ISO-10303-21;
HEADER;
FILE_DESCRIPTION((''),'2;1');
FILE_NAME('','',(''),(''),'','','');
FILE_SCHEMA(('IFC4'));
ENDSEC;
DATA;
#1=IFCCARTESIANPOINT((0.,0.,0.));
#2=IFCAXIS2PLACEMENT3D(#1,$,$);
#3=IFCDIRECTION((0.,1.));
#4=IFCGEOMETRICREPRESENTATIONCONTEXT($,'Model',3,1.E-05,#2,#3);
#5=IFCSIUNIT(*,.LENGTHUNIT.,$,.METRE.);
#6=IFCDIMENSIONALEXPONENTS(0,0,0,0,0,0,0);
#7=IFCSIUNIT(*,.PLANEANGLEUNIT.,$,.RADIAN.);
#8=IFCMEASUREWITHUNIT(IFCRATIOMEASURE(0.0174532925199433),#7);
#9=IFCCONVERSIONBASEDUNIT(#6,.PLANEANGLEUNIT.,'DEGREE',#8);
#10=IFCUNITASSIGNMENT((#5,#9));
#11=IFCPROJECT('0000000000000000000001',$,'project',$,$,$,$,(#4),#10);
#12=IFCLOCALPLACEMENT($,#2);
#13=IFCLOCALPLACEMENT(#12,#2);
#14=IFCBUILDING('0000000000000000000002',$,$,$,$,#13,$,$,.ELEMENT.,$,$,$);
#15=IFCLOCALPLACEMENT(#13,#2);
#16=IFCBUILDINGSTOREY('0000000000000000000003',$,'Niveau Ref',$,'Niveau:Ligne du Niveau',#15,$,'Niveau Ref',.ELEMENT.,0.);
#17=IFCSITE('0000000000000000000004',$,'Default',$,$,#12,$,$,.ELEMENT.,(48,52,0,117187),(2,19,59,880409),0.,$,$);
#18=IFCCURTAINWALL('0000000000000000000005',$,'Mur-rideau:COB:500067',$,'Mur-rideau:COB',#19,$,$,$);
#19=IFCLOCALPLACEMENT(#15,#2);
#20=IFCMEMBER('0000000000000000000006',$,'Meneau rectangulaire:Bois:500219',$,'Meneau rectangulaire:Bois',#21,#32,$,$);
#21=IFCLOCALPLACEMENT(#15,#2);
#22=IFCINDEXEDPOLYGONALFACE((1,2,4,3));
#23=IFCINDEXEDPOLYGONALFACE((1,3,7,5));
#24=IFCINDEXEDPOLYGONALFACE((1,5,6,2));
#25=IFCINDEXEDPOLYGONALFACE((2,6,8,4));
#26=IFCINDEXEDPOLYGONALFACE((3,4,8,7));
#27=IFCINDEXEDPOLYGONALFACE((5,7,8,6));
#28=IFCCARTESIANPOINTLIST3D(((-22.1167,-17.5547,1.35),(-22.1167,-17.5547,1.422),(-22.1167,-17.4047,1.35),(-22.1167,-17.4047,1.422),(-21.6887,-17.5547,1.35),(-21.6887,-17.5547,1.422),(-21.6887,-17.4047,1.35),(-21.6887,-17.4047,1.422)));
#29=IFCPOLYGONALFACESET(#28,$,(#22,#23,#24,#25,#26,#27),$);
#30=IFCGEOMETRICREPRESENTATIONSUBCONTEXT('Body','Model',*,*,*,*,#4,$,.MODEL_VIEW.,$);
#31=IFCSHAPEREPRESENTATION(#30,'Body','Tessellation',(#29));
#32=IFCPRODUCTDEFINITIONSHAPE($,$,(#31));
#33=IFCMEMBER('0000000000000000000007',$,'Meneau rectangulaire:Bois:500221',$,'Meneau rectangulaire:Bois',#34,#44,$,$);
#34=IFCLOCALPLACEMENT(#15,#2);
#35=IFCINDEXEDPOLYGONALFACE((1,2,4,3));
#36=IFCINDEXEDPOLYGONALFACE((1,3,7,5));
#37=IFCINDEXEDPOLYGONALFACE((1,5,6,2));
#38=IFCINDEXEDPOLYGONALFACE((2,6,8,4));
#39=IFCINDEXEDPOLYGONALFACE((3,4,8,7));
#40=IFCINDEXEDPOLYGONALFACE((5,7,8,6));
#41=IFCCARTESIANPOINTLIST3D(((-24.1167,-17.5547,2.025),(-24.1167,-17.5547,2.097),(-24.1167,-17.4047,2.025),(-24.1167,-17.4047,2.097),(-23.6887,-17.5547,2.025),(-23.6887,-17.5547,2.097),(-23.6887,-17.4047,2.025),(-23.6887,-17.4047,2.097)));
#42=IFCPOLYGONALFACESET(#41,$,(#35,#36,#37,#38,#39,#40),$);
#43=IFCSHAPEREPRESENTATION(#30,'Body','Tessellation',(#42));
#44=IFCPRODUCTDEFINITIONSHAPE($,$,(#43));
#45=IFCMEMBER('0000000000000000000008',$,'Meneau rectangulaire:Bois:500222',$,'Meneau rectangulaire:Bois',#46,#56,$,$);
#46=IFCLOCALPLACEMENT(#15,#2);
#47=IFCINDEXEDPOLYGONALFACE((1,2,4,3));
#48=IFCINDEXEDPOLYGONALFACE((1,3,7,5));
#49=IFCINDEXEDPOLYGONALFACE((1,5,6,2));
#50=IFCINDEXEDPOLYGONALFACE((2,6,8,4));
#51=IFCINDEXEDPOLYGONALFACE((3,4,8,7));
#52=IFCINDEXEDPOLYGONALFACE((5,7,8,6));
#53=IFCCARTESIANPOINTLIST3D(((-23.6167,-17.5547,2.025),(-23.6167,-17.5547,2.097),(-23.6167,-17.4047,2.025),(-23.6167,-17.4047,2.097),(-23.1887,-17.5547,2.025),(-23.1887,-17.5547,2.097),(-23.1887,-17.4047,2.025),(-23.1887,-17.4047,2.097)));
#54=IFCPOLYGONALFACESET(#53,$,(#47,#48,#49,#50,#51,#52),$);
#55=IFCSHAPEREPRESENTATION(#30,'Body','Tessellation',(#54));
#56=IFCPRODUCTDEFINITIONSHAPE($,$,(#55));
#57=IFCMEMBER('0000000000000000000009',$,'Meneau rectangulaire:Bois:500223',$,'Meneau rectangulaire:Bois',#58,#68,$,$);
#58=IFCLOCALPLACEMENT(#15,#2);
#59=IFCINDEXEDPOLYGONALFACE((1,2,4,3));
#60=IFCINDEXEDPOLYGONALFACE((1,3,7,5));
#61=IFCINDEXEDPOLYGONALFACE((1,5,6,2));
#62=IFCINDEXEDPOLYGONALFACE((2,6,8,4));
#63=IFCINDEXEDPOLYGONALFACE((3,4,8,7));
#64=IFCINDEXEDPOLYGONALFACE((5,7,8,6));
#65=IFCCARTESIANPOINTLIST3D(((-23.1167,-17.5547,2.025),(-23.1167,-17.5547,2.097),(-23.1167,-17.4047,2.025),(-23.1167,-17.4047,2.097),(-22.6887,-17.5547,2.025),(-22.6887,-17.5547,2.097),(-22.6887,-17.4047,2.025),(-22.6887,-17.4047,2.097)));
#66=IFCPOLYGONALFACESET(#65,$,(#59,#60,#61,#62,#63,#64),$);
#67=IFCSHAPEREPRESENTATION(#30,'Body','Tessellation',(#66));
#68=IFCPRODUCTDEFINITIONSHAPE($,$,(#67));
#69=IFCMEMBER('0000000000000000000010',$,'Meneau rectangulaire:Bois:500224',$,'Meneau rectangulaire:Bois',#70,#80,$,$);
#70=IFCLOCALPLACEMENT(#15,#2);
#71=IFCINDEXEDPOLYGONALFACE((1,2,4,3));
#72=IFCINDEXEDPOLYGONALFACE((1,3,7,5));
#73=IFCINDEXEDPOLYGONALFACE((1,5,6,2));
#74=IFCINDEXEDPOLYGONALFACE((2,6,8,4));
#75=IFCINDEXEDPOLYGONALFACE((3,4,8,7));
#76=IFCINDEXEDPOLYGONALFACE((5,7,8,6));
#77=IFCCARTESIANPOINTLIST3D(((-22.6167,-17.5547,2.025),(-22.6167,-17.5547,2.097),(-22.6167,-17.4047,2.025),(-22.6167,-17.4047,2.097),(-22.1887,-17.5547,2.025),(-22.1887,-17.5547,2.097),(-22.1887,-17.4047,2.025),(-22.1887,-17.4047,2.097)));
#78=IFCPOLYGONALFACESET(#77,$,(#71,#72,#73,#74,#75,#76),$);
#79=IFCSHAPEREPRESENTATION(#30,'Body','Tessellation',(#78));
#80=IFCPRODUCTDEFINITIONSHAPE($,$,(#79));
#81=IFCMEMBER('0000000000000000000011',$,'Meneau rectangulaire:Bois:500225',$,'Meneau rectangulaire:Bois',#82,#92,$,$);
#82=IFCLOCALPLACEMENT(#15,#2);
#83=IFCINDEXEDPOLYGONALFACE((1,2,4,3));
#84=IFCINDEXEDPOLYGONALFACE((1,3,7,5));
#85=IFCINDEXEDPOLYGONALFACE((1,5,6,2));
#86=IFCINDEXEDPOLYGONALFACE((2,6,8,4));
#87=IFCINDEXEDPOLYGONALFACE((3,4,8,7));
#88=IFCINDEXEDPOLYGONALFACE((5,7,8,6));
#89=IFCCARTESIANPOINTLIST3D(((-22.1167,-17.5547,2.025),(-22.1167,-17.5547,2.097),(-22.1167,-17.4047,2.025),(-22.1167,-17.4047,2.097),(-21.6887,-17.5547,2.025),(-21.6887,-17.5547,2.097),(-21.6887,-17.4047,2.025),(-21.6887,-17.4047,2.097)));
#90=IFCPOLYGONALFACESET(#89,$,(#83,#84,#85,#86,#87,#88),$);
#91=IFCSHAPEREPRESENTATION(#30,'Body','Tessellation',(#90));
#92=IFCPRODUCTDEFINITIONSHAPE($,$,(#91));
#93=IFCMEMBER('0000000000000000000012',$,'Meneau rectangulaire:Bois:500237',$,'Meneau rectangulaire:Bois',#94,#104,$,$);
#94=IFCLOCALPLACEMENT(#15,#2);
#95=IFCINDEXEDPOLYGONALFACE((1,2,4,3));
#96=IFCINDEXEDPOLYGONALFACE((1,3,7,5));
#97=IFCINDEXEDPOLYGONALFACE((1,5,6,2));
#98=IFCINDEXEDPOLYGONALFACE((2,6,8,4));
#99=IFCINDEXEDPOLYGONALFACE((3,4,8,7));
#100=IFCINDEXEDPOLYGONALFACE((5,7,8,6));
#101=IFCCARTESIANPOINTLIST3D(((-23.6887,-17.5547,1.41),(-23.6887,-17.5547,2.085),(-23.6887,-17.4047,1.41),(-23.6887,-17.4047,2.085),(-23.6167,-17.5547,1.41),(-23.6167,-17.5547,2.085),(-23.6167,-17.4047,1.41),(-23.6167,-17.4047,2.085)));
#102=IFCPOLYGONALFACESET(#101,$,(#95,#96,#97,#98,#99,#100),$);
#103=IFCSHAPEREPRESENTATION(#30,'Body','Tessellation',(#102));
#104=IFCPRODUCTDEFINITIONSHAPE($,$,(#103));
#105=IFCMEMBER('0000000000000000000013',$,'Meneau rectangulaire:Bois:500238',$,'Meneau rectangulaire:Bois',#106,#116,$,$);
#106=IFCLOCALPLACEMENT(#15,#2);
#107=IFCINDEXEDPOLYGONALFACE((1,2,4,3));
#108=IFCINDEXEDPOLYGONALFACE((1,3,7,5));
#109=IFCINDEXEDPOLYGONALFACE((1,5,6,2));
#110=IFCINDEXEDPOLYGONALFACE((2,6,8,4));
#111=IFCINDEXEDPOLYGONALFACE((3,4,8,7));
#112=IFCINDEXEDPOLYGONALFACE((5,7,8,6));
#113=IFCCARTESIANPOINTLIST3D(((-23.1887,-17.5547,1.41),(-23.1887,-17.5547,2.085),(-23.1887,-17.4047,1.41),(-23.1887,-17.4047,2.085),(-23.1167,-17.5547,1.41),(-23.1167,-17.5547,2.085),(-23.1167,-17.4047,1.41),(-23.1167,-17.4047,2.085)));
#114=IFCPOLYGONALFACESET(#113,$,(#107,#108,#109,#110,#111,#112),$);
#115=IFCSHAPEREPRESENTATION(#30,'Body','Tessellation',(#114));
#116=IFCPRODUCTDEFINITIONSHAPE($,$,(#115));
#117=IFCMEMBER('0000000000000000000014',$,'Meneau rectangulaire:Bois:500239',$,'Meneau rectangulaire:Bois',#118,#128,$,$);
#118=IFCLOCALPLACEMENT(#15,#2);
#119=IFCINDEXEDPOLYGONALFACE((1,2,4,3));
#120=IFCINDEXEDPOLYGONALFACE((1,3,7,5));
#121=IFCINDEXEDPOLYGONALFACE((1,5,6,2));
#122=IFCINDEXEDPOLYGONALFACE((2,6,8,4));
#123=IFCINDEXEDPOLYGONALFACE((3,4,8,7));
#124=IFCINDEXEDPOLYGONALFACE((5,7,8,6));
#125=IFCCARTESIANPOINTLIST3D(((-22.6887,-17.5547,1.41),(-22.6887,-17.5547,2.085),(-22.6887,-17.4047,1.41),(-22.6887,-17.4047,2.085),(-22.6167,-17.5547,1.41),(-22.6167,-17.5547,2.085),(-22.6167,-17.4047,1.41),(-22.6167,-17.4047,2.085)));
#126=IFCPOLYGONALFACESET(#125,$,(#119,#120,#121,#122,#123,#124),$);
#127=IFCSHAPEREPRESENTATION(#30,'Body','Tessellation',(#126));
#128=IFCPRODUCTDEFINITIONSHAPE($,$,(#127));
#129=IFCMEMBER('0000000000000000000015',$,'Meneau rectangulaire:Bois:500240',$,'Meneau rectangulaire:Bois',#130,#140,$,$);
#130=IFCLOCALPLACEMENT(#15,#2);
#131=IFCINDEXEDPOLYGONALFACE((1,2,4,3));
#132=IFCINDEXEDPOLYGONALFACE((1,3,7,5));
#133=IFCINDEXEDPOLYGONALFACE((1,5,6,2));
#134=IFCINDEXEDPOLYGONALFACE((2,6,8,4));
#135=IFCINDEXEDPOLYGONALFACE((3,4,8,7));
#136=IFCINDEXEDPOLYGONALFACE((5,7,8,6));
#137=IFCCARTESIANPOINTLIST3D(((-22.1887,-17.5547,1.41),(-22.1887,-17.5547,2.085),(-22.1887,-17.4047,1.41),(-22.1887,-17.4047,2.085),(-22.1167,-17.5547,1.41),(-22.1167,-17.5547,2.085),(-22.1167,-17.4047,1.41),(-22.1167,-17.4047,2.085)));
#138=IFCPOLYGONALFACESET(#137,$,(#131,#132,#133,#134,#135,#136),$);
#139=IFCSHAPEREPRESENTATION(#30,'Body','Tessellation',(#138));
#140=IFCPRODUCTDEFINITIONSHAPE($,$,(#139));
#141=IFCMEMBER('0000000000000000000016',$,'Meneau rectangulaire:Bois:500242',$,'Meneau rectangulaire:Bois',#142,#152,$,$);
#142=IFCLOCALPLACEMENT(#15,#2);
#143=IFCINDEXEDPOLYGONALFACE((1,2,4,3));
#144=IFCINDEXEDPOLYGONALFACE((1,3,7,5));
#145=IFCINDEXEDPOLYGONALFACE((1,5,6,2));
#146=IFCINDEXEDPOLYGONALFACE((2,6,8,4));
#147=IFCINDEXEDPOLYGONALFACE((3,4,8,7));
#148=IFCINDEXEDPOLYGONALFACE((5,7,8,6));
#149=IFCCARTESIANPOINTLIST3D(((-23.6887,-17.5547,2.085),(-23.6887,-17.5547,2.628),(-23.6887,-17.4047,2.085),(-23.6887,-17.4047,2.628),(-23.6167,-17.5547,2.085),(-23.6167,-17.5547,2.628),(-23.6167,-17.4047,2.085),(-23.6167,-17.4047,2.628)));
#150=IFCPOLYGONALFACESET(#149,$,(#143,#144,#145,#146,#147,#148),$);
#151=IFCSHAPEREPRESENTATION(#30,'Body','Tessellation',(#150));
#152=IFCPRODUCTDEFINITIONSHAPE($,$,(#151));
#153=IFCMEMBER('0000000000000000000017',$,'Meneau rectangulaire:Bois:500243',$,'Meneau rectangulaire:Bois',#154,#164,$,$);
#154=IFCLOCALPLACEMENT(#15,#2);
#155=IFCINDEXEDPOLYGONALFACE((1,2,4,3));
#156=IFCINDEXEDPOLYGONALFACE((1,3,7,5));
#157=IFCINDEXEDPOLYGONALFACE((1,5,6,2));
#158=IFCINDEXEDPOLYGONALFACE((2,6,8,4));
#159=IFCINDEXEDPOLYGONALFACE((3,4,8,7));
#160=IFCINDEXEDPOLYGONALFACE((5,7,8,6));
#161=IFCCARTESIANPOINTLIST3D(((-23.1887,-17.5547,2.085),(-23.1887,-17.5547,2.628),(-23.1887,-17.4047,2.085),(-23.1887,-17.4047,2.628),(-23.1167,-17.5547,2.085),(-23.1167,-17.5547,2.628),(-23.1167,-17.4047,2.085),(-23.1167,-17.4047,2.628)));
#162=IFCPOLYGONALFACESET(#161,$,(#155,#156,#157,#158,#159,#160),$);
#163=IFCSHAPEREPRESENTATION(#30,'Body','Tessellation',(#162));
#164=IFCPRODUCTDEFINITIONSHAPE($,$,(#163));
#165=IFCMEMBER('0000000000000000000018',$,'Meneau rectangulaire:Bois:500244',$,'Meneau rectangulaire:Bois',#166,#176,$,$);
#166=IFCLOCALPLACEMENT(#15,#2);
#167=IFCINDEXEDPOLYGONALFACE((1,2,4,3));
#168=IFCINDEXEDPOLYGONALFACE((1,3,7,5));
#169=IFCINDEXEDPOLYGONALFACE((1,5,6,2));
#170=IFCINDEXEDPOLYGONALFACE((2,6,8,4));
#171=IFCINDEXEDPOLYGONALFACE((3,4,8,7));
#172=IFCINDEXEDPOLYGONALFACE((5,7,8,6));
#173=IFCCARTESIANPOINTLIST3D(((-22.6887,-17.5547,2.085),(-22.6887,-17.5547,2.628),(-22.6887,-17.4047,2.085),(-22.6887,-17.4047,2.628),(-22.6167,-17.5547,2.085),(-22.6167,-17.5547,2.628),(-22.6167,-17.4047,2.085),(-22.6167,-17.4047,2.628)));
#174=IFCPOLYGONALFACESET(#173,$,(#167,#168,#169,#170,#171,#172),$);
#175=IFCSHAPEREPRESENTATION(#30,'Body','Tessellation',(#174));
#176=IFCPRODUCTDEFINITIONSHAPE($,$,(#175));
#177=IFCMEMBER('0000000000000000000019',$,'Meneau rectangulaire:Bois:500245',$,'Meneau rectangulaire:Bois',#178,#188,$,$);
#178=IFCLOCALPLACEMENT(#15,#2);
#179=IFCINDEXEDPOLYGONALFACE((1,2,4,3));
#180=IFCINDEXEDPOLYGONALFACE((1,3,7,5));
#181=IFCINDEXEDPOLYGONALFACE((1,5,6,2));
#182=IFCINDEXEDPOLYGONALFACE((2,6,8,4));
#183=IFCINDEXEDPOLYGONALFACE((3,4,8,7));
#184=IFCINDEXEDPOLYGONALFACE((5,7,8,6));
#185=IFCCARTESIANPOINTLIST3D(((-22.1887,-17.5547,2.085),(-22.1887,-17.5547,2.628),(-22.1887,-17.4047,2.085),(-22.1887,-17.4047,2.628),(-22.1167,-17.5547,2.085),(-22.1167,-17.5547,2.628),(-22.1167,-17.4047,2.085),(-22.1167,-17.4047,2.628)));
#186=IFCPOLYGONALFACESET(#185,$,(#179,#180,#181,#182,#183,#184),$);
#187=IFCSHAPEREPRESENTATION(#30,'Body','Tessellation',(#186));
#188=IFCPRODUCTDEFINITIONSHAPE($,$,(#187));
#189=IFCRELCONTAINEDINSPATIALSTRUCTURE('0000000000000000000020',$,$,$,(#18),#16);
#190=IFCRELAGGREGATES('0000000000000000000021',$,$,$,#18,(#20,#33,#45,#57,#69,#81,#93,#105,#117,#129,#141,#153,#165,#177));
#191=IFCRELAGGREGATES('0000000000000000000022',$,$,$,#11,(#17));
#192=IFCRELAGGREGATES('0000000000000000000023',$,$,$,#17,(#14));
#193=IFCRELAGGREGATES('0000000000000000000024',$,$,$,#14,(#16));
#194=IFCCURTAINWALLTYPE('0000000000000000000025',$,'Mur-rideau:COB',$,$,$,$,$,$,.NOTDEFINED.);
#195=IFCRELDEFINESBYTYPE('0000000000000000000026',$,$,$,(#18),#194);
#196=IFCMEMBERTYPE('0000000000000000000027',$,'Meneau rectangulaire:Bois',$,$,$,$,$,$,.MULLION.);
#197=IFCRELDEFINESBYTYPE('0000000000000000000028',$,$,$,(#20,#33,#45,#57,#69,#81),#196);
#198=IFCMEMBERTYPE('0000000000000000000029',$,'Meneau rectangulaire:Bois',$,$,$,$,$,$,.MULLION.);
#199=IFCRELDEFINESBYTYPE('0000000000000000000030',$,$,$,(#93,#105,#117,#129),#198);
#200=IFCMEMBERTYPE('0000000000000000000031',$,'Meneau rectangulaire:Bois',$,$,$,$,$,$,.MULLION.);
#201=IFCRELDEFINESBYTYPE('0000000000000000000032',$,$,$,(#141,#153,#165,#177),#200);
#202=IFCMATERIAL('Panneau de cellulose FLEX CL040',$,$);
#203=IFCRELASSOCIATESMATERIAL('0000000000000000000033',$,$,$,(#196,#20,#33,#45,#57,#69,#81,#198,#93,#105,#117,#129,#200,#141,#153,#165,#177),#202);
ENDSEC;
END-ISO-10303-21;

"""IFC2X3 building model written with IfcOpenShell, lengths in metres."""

from ifc_helpers import new_model, entity, si_unit, converted_unit, direction, frame, origin, origin_2d_with_axis, place, context, subcontext, project, spatial, rectangle, extrude, source, transform, mapped, material, type_object, type_shapes, element, aggregate, save


model = new_model("IFC2X3")

# Units and contexts
model_context = context("Model", 3, precision=1e-05, world=origin(), true_north=direction((0.0, 1.0)))
body_context = subcontext(model_context, "Body", "Model", "MODEL_VIEW")
ifc_project = project(units=[si_unit("LENGTHUNIT", "METRE"), converted_unit("PLANEANGLEUNIT", "DEGREE", entity("IfcRatioMeasure", 0.0174532925199433), si_unit("PLANEANGLEUNIT", "RADIAN"), dimensions=[0, 0, 0, 0, 0, 0, 0])], contexts=[model_context])

# Site, building, storey
site_placement = place(None, origin())
site = spatial("IfcSite", under=ifc_project, at=site_placement, Name="Default", CompositionType="ELEMENT", RefLatitude=(48, 52, 0, 117187), RefLongitude=(2, 19, 59, 880409), RefElevation=0.0)
building_placement = place(site_placement, origin())
building = spatial("IfcBuilding", under=site, at=building_placement, CompositionType="ELEMENT")
storey_placement = place(building_placement, origin())
storey = spatial("IfcBuildingStorey", under=building, at=storey_placement, Name="Niveau Ref", ObjectType="Niveau:Ligne du Niveau", LongName="Niveau Ref", CompositionType="ELEMENT", Elevation=0.0)

# Curtain wall, members
curtain_wall_type = type_object("IfcCurtainWallType", Name="Mur-rideau:COB", PredefinedType="NOTDEFINED")
curtain_wall_placement = place(storey_placement, origin())
curtain_wall = element("IfcCurtainWall", 1, at=curtain_wall_placement, inside=storey, type_object=curtain_wall_type, Name="Mur-rideau:COB:500067", ObjectType="Mur-rideau:COB")
ifc_material = material(Name="Panneau de cellulose FLEX CL040")
member_type_1 = type_object("IfcMemberType", Name="Meneau rectangulaire:Bois", PredefinedType="MULLION", material=ifc_material)
shared_shape_1 = source(origin(), body_context, "Body", "SweptSolid", [
    extrude(rectangle(XDim=0.15, YDim=0.072, at=origin_2d_with_axis()), frame((-0.024, 0.0, -0.428), z_axis=(0.0, 0.0, 1.0), x_axis=(0.0, -1.0, 0.0)), (0.0, 0.0, 1.0), 0.428),
])
type_shapes(member_type_1, [shared_shape_1])
member_1_placement = place(storey_placement, frame((-21.6887, -17.4797, 1.41), z_axis=(1.0, 0.0, 0.0), x_axis=(0.0, 0.0, 1.0)))
member_1 = element("IfcMember", 2, at=member_1_placement, type_object=member_type_1, material=ifc_material, Name="Meneau rectangulaire:Bois:500219", ObjectType="Meneau rectangulaire:Bois", context=body_context, shape_type="MappedRepresentation", body=[
    mapped(shared_shape_1, transform((0.0, 0.0, 0.0), scale=1.0)),
])
member_2_placement = place(storey_placement, frame((-23.6887, -17.4797, 2.085), z_axis=(1.0, 0.0, 0.0), x_axis=(0.0, 0.0, 1.0)))
member_2 = element("IfcMember", 3, at=member_2_placement, type_object=member_type_1, material=ifc_material, Name="Meneau rectangulaire:Bois:500221", ObjectType="Meneau rectangulaire:Bois", context=body_context, shape_type="MappedRepresentation", body=[
    mapped(shared_shape_1, transform((0.0, 0.0, 0.0), scale=1.0)),
])
member_3_placement = place(storey_placement, frame((-23.1887, -17.4797, 2.085), z_axis=(1.0, 0.0, 0.0), x_axis=(0.0, 0.0, 1.0)))
member_3 = element("IfcMember", 4, at=member_3_placement, type_object=member_type_1, material=ifc_material, Name="Meneau rectangulaire:Bois:500222", ObjectType="Meneau rectangulaire:Bois", context=body_context, shape_type="MappedRepresentation", body=[
    mapped(shared_shape_1, transform((0.0, 0.0, 0.0), scale=1.0)),
])
member_4_placement = place(storey_placement, frame((-22.6887, -17.4797, 2.085), z_axis=(1.0, 0.0, 0.0), x_axis=(0.0, 0.0, 1.0)))
member_4 = element("IfcMember", 5, at=member_4_placement, type_object=member_type_1, material=ifc_material, Name="Meneau rectangulaire:Bois:500223", ObjectType="Meneau rectangulaire:Bois", context=body_context, shape_type="MappedRepresentation", body=[
    mapped(shared_shape_1, transform((0.0, 0.0, 0.0), scale=1.0)),
])
member_5_placement = place(storey_placement, frame((-22.1887, -17.4797, 2.085), z_axis=(1.0, 0.0, 0.0), x_axis=(0.0, 0.0, 1.0)))
member_5 = element("IfcMember", 6, at=member_5_placement, type_object=member_type_1, material=ifc_material, Name="Meneau rectangulaire:Bois:500224", ObjectType="Meneau rectangulaire:Bois", context=body_context, shape_type="MappedRepresentation", body=[
    mapped(shared_shape_1, transform((0.0, 0.0, 0.0), scale=1.0)),
])
member_6_placement = place(storey_placement, frame((-21.6887, -17.4797, 2.085), z_axis=(1.0, 0.0, 0.0), x_axis=(0.0, 0.0, 1.0)))
member_6 = element("IfcMember", 7, at=member_6_placement, type_object=member_type_1, material=ifc_material, Name="Meneau rectangulaire:Bois:500225", ObjectType="Meneau rectangulaire:Bois", context=body_context, shape_type="MappedRepresentation", body=[
    mapped(shared_shape_1, transform((0.0, 0.0, 0.0), scale=1.0)),
])
member_type_2 = type_object("IfcMemberType", Name="Meneau rectangulaire:Bois", PredefinedType="MULLION", material=ifc_material)
shared_shape_2 = source(origin(), body_context, "Body", "SweptSolid", [
    extrude(rectangle(XDim=0.15, YDim=0.072, at=origin_2d_with_axis()), frame((-0.024, 0.0, -0.675), z_axis=(0.0, 0.0, 1.0), x_axis=(0.0, -1.0, 0.0)), (0.0, 0.0, 1.0), 0.675),
])
type_shapes(member_type_2, [shared_shape_2])
member_7_placement = place(storey_placement, frame((-23.6287, -17.4797, 1.41), z_axis=(0.0, 0.0, -1.0), x_axis=(1.0, 0.0, 0.0)))
member_7 = element("IfcMember", 8, at=member_7_placement, type_object=member_type_2, material=ifc_material, Name="Meneau rectangulaire:Bois:500237", ObjectType="Meneau rectangulaire:Bois", context=body_context, shape_type="MappedRepresentation", body=[
    mapped(shared_shape_2, transform((0.0, 0.0, 0.0), scale=1.0)),
])
member_8_placement = place(storey_placement, frame((-23.1287, -17.4797, 1.41), z_axis=(0.0, 0.0, -1.0), x_axis=(1.0, 0.0, 0.0)))
member_8 = element("IfcMember", 9, at=member_8_placement, type_object=member_type_2, material=ifc_material, Name="Meneau rectangulaire:Bois:500238", ObjectType="Meneau rectangulaire:Bois", context=body_context, shape_type="MappedRepresentation", body=[
    mapped(shared_shape_2, transform((0.0, 0.0, 0.0), scale=1.0)),
])
member_9_placement = place(storey_placement, frame((-22.6287, -17.4797, 1.41), z_axis=(0.0, 0.0, -1.0), x_axis=(1.0, 0.0, 0.0)))
member_9 = element("IfcMember", 10, at=member_9_placement, type_object=member_type_2, material=ifc_material, Name="Meneau rectangulaire:Bois:500239", ObjectType="Meneau rectangulaire:Bois", context=body_context, shape_type="MappedRepresentation", body=[
    mapped(shared_shape_2, transform((0.0, 0.0, 0.0), scale=1.0)),
])
member_10_placement = place(storey_placement, frame((-22.1287, -17.4797, 1.41), z_axis=(0.0, 0.0, -1.0), x_axis=(1.0, 0.0, 0.0)))
member_10 = element("IfcMember", 11, at=member_10_placement, type_object=member_type_2, material=ifc_material, Name="Meneau rectangulaire:Bois:500240", ObjectType="Meneau rectangulaire:Bois", context=body_context, shape_type="MappedRepresentation", body=[
    mapped(shared_shape_2, transform((0.0, 0.0, 0.0), scale=1.0)),
])
member_type_3 = type_object("IfcMemberType", Name="Meneau rectangulaire:Bois", PredefinedType="MULLION", material=ifc_material)
shared_shape_3 = source(origin(), body_context, "Body", "SweptSolid", [
    extrude(rectangle(XDim=0.15, YDim=0.072, at=origin_2d_with_axis()), frame((-0.024, 0.0, -0.543), z_axis=(0.0, 0.0, 1.0), x_axis=(0.0, -1.0, 0.0)), (0.0, 0.0, 1.0), 0.543),
])
type_shapes(member_type_3, [shared_shape_3])
member_11_placement = place(storey_placement, frame((-23.6287, -17.4797, 2.085), z_axis=(0.0, 0.0, -1.0), x_axis=(1.0, 0.0, 0.0)))
member_11 = element("IfcMember", 12, at=member_11_placement, type_object=member_type_3, material=ifc_material, Name="Meneau rectangulaire:Bois:500242", ObjectType="Meneau rectangulaire:Bois", context=body_context, shape_type="MappedRepresentation", body=[
    mapped(shared_shape_3, transform((0.0, 0.0, 0.0), scale=1.0)),
])
member_12_placement = place(storey_placement, frame((-23.1287, -17.4797, 2.085), z_axis=(0.0, 0.0, -1.0), x_axis=(1.0, 0.0, 0.0)))
member_12 = element("IfcMember", 13, at=member_12_placement, type_object=member_type_3, material=ifc_material, Name="Meneau rectangulaire:Bois:500243", ObjectType="Meneau rectangulaire:Bois", context=body_context, shape_type="MappedRepresentation", body=[
    mapped(shared_shape_3, transform((0.0, 0.0, 0.0), scale=1.0)),
])
member_13_placement = place(storey_placement, frame((-22.6287, -17.4797, 2.085), z_axis=(0.0, 0.0, -1.0), x_axis=(1.0, 0.0, 0.0)))
member_13 = element("IfcMember", 14, at=member_13_placement, type_object=member_type_3, material=ifc_material, Name="Meneau rectangulaire:Bois:500244", ObjectType="Meneau rectangulaire:Bois", context=body_context, shape_type="MappedRepresentation", body=[
    mapped(shared_shape_3, transform((0.0, 0.0, 0.0), scale=1.0)),
])
member_14_placement = place(storey_placement, frame((-22.1287, -17.4797, 2.085), z_axis=(0.0, 0.0, -1.0), x_axis=(1.0, 0.0, 0.0)))
member_14 = element("IfcMember", 15, at=member_14_placement, type_object=member_type_3, material=ifc_material, Name="Meneau rectangulaire:Bois:500245", ObjectType="Meneau rectangulaire:Bois", context=body_context, shape_type="MappedRepresentation", body=[
    mapped(shared_shape_3, transform((0.0, 0.0, 0.0), scale=1.0)),
])
aggregate(curtain_wall, [member_1, member_2, member_3, member_4, member_5, member_6, member_7, member_8, member_9, member_10, member_11, member_12, member_13, member_14])

save(model, "model.ifc")
